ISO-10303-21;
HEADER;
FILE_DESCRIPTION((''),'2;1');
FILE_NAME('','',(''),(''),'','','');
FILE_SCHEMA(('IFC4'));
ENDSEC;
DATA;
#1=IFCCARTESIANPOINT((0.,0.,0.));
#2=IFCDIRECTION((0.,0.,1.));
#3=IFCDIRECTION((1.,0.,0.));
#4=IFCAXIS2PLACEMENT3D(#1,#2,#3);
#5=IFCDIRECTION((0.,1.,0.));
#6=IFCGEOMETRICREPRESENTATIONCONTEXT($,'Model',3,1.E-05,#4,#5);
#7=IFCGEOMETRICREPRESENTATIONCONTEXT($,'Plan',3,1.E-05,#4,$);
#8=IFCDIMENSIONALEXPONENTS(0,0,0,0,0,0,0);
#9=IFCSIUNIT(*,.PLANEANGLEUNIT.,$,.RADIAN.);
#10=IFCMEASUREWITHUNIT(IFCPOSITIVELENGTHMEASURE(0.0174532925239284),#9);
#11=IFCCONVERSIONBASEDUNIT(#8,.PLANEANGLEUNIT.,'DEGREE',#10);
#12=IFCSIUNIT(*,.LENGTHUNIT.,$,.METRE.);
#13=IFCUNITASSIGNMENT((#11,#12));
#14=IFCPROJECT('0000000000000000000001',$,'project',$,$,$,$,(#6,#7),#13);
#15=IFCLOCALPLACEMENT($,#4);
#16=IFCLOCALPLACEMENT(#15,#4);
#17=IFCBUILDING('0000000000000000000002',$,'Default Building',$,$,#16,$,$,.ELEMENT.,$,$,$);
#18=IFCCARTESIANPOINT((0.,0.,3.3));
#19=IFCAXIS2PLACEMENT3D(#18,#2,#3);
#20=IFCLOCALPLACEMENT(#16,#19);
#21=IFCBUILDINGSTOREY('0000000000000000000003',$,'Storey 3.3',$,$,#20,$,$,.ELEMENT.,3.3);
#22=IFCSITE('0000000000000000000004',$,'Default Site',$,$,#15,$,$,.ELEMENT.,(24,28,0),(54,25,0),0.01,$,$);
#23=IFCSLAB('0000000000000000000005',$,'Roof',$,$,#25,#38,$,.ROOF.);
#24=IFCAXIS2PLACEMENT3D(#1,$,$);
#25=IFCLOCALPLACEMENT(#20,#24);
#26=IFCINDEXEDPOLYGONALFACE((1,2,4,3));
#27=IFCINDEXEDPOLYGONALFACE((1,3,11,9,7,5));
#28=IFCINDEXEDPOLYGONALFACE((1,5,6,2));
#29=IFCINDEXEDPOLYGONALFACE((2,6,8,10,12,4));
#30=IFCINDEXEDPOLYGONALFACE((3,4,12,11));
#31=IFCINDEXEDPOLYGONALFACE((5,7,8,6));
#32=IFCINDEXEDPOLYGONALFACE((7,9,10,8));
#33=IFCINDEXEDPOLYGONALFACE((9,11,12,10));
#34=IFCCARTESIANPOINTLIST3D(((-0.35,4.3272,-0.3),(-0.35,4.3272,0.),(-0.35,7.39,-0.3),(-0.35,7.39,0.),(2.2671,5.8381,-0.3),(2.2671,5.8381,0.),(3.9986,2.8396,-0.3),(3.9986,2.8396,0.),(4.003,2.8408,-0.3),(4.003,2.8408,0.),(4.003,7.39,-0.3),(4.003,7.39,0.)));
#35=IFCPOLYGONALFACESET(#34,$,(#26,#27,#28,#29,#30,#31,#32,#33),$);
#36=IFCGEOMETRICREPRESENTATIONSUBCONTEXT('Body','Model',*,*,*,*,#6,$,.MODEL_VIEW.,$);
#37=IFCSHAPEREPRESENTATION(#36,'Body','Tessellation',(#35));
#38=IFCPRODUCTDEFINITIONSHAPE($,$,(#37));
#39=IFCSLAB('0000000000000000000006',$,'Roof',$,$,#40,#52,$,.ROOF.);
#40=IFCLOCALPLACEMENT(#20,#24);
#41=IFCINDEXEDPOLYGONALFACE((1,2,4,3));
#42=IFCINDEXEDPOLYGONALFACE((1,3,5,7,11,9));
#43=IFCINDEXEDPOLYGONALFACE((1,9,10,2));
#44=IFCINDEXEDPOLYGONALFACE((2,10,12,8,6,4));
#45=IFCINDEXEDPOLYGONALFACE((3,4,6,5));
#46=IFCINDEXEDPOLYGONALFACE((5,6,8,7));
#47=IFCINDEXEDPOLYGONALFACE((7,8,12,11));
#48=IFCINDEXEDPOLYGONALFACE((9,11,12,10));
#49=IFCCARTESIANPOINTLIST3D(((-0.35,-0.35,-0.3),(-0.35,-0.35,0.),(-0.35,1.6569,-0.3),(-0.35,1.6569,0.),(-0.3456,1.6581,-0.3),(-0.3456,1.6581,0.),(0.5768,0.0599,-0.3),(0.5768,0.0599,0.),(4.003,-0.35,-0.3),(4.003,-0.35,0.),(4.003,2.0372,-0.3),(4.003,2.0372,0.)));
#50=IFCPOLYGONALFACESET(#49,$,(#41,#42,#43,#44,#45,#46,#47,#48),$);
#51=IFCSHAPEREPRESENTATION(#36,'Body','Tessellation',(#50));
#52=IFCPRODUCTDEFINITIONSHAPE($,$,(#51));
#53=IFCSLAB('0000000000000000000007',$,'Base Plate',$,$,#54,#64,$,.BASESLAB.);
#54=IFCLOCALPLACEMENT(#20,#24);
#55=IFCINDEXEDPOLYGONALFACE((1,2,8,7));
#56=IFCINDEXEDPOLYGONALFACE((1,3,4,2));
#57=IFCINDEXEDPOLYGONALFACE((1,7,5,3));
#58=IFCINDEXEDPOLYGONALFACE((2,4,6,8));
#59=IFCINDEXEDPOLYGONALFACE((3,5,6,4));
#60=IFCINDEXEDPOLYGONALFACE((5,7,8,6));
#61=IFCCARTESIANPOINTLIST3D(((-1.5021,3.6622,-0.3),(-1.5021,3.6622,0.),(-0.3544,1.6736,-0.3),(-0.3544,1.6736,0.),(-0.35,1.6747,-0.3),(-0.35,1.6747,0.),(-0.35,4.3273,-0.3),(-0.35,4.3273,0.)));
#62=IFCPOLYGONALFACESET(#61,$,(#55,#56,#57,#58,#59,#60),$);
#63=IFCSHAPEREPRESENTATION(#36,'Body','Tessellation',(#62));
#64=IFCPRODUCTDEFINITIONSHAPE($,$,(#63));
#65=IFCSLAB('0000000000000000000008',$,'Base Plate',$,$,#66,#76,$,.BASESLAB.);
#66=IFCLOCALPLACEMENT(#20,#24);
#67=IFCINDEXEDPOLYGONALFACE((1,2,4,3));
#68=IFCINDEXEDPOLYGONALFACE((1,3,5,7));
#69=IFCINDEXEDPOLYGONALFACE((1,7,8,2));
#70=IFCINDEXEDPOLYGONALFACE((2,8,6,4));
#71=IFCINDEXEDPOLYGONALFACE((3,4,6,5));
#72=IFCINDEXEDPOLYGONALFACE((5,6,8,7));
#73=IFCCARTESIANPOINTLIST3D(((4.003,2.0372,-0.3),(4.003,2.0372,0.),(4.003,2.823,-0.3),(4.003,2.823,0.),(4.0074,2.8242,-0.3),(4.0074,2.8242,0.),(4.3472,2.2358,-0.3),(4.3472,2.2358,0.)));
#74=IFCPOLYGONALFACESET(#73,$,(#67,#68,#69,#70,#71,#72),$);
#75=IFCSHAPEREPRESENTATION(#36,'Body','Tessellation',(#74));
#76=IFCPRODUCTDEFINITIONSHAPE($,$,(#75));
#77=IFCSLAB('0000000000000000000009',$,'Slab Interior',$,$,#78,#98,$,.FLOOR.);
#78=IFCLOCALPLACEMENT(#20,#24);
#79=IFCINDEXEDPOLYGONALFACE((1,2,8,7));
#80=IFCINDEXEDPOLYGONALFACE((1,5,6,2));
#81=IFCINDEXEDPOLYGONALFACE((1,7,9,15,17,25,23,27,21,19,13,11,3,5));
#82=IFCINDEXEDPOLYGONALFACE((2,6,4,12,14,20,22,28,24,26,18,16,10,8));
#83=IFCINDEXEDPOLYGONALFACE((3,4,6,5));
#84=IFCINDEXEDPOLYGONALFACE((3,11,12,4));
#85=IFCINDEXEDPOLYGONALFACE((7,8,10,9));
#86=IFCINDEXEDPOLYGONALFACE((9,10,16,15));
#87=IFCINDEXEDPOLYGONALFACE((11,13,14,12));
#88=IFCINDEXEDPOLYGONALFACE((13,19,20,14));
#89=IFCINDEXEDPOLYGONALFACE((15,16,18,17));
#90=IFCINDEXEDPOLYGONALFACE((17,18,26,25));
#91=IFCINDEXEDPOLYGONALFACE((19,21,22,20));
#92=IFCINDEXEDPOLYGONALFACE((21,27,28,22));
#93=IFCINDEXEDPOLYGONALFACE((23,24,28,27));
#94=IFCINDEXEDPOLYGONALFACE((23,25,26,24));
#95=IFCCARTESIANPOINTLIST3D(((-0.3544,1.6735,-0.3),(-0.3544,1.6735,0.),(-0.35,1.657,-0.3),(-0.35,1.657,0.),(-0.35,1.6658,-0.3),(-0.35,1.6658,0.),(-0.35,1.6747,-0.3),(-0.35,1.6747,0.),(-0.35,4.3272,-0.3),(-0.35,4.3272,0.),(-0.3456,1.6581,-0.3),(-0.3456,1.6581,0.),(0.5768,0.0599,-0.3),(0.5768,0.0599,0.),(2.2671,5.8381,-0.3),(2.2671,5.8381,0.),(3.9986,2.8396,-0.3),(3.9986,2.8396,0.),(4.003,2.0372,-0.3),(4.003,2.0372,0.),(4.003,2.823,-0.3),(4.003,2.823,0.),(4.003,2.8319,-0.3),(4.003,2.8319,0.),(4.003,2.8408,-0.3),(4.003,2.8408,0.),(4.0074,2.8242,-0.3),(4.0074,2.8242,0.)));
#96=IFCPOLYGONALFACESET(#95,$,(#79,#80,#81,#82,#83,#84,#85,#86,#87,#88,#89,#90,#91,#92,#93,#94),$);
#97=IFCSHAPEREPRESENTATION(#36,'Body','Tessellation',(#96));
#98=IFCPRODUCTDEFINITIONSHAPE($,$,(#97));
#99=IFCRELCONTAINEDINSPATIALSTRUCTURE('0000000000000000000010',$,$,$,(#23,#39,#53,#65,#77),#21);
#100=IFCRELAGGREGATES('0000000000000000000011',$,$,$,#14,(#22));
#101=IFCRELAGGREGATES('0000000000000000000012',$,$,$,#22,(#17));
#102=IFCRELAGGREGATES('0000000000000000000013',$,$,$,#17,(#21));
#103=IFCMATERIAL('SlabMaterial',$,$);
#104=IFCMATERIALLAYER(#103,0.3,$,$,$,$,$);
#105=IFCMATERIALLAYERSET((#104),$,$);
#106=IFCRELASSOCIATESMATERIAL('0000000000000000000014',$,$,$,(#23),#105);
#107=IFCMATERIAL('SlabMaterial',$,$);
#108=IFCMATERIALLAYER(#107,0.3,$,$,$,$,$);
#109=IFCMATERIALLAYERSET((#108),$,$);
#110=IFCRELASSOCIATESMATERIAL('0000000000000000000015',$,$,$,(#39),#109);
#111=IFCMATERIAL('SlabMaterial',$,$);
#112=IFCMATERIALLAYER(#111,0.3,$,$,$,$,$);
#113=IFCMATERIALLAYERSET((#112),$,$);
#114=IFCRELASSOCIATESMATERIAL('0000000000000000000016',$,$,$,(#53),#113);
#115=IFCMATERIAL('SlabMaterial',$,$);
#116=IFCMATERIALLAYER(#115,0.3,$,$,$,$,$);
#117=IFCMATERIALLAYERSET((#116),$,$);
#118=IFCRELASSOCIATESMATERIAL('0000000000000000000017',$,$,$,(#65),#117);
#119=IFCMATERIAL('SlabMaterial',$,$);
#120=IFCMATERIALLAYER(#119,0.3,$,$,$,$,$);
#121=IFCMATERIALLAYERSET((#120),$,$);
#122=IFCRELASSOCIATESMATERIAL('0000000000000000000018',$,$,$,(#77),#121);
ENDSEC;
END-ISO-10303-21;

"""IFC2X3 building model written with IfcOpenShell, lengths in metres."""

from ifc_helpers import new_model, entity, si_unit, converted_unit, direction, frame, origin_with_axes, place, context, subcontext, project, spatial, polyline, outline, extrude, material, layer, layer_set, layer_usage, element, save


model = new_model("IFC2X3")

# Units and contexts
model_context = context("Model", 3, precision=1e-05, world=origin_with_axes(), true_north=direction((0.0, 1.0, 0.0)))
plan_context = context("Plan", 3, precision=1e-05, world=origin_with_axes())
body_context = subcontext(model_context, "Body", "Model", "MODEL_VIEW")
ifc_project = project(units=[converted_unit("PLANEANGLEUNIT", "DEGREE", entity("IfcPositiveLengthMeasure", 0.0174532925239284), si_unit("PLANEANGLEUNIT", "RADIAN"), dimensions=[0, 0, 0, 0, 0, 0, 0]), si_unit("LENGTHUNIT", "METRE")], contexts=[model_context, plan_context])

# Site, building, storey
site_placement = place(None, origin_with_axes())
site = spatial("IfcSite", under=ifc_project, at=site_placement, Name="Default Site", CompositionType="ELEMENT", RefLatitude=(24, 28, 0), RefLongitude=(54, 25, 0), RefElevation=0.01)
building_placement = place(site_placement, origin_with_axes())
building = spatial("IfcBuilding", under=site, at=building_placement, Name="Default Building", CompositionType="ELEMENT")
storey_placement = place(building_placement, frame((0.0, 0.0, 3.3), z_axis=(0.0, 0.0, 1.0), x_axis=(1.0, 0.0, 0.0)))
storey = spatial("IfcBuildingStorey", under=building, at=storey_placement, Name="Storey 3.3", CompositionType="ELEMENT", Elevation=3.3)

# Slabs
ifc_material_1 = material(Name="SlabMaterial")
ifc_layer_1 = layer(ifc_material_1, 0.3)
ifc_layer_set_1 = layer_set([ifc_layer_1])
ifc_layer_usage_1 = layer_usage(ifc_layer_set_1, "AXIS2", "POSITIVE", 0.3)
slab_1_placement = place(storey_placement, frame((0.0, 0.0, -0.3), z_axis=(0.0, 0.0, 1.0), x_axis=(1.0, 0.0, 0.0)))
element("IfcSlab", 1, at=slab_1_placement, inside=storey, material=ifc_layer_usage_1, Name="Roof", PredefinedType="ROOF", context=body_context, shape_type="SweptSolid", body=[
    extrude(outline(polyline([(4.003, 2.8408), (4.003, 7.39), (-0.35, 7.39), (-0.35, 4.3272), (2.2671, 5.8381), (3.9986, 2.8396), (4.003, 2.8408)])), origin_with_axes(), (0.0, 0.0, 1.0), 0.3),
])
ifc_material_2 = material(Name="SlabMaterial")
ifc_layer_2 = layer(ifc_material_2, 0.3)
ifc_layer_set_2 = layer_set([ifc_layer_2])
ifc_layer_usage_2 = layer_usage(ifc_layer_set_2, "AXIS2", "POSITIVE", 0.3)
slab_2_placement = place(storey_placement, frame((0.0, 0.0, -0.3), z_axis=(0.0, 0.0, 1.0), x_axis=(1.0, 0.0, 0.0)))
element("IfcSlab", 2, at=slab_2_placement, inside=storey, material=ifc_layer_usage_2, Name="Roof", PredefinedType="ROOF", context=body_context, shape_type="SweptSolid", body=[
    extrude(outline(polyline([(4.003, 2.0372), (4.003, -0.35), (-0.35, -0.35), (-0.35, 1.6569), (-0.3456, 1.6581), (0.5768, 0.0599), (4.003, 2.0372)])), origin_with_axes(), (0.0, 0.0, 1.0), 0.3),
])
ifc_material_3 = material(Name="SlabMaterial")
ifc_layer_3 = layer(ifc_material_3, 0.3)
ifc_layer_set_3 = layer_set([ifc_layer_3])
ifc_layer_usage_3 = layer_usage(ifc_layer_set_3, "AXIS2", "POSITIVE", 0.3)
slab_3_placement = place(storey_placement, frame((0.0, 0.0, -0.3), z_axis=(0.0, 0.0, 1.0), x_axis=(1.0, 0.0, 0.0)))
element("IfcSlab", 3, at=slab_3_placement, inside=storey, material=ifc_layer_usage_3, Name="Base Plate", PredefinedType="BASESLAB", context=body_context, shape_type="SweptSolid", body=[
    extrude(outline(polyline([(-0.35, 1.6747), (-0.35, 4.3273), (-1.5021, 3.6622), (-0.3544, 1.6736), (-0.35, 1.6747)])), origin_with_axes(), (0.0, 0.0, 1.0), 0.3),
])
ifc_material_4 = material(Name="SlabMaterial")
ifc_layer_4 = layer(ifc_material_4, 0.3)
ifc_layer_set_4 = layer_set([ifc_layer_4])
ifc_layer_usage_4 = layer_usage(ifc_layer_set_4, "AXIS2", "POSITIVE", 0.3)
slab_4_placement = place(storey_placement, frame((0.0, 0.0, -0.3), z_axis=(0.0, 0.0, 1.0), x_axis=(1.0, 0.0, 0.0)))
element("IfcSlab", 4, at=slab_4_placement, inside=storey, material=ifc_layer_usage_4, Name="Base Plate", PredefinedType="BASESLAB", context=body_context, shape_type="SweptSolid", body=[
    extrude(outline(polyline([(4.3472, 2.2358), (4.0074, 2.8242), (4.003, 2.823), (4.003, 2.0372), (4.3472, 2.2358)])), origin_with_axes(), (0.0, 0.0, 1.0), 0.3),
])
ifc_material_5 = material(Name="SlabMaterial")
ifc_layer_5 = layer(ifc_material_5, 0.3)
ifc_layer_set_5 = layer_set([ifc_layer_5])
ifc_layer_usage_5 = layer_usage(ifc_layer_set_5, "AXIS2", "POSITIVE", 0.3)
slab_5_placement = place(storey_placement, frame((0.0, 0.0, -0.3), z_axis=(0.0, 0.0, 1.0), x_axis=(1.0, 0.0, 0.0)))
element("IfcSlab", 5, at=slab_5_placement, inside=storey, material=ifc_layer_usage_5, Name="Slab Interior", PredefinedType="FLOOR", context=body_context, shape_type="SweptSolid", body=[
    extrude(outline(polyline([(4.003, 2.0372), (4.003, 2.823), (4.0074, 2.8242), (4.003, 2.8319), (4.003, 2.8408), (3.9986, 2.8396), (2.2671, 5.8381), (-0.35, 4.3272), (-0.35, 1.6747), (-0.3544, 1.6735), (-0.35, 1.6658), (-0.35, 1.657), (-0.3456, 1.6581), (0.5768, 0.0599), (4.003, 2.0372)])), origin_with_axes(), (0.0, 0.0, 1.0), 0.3),
])

save(model, "model.ifc")
